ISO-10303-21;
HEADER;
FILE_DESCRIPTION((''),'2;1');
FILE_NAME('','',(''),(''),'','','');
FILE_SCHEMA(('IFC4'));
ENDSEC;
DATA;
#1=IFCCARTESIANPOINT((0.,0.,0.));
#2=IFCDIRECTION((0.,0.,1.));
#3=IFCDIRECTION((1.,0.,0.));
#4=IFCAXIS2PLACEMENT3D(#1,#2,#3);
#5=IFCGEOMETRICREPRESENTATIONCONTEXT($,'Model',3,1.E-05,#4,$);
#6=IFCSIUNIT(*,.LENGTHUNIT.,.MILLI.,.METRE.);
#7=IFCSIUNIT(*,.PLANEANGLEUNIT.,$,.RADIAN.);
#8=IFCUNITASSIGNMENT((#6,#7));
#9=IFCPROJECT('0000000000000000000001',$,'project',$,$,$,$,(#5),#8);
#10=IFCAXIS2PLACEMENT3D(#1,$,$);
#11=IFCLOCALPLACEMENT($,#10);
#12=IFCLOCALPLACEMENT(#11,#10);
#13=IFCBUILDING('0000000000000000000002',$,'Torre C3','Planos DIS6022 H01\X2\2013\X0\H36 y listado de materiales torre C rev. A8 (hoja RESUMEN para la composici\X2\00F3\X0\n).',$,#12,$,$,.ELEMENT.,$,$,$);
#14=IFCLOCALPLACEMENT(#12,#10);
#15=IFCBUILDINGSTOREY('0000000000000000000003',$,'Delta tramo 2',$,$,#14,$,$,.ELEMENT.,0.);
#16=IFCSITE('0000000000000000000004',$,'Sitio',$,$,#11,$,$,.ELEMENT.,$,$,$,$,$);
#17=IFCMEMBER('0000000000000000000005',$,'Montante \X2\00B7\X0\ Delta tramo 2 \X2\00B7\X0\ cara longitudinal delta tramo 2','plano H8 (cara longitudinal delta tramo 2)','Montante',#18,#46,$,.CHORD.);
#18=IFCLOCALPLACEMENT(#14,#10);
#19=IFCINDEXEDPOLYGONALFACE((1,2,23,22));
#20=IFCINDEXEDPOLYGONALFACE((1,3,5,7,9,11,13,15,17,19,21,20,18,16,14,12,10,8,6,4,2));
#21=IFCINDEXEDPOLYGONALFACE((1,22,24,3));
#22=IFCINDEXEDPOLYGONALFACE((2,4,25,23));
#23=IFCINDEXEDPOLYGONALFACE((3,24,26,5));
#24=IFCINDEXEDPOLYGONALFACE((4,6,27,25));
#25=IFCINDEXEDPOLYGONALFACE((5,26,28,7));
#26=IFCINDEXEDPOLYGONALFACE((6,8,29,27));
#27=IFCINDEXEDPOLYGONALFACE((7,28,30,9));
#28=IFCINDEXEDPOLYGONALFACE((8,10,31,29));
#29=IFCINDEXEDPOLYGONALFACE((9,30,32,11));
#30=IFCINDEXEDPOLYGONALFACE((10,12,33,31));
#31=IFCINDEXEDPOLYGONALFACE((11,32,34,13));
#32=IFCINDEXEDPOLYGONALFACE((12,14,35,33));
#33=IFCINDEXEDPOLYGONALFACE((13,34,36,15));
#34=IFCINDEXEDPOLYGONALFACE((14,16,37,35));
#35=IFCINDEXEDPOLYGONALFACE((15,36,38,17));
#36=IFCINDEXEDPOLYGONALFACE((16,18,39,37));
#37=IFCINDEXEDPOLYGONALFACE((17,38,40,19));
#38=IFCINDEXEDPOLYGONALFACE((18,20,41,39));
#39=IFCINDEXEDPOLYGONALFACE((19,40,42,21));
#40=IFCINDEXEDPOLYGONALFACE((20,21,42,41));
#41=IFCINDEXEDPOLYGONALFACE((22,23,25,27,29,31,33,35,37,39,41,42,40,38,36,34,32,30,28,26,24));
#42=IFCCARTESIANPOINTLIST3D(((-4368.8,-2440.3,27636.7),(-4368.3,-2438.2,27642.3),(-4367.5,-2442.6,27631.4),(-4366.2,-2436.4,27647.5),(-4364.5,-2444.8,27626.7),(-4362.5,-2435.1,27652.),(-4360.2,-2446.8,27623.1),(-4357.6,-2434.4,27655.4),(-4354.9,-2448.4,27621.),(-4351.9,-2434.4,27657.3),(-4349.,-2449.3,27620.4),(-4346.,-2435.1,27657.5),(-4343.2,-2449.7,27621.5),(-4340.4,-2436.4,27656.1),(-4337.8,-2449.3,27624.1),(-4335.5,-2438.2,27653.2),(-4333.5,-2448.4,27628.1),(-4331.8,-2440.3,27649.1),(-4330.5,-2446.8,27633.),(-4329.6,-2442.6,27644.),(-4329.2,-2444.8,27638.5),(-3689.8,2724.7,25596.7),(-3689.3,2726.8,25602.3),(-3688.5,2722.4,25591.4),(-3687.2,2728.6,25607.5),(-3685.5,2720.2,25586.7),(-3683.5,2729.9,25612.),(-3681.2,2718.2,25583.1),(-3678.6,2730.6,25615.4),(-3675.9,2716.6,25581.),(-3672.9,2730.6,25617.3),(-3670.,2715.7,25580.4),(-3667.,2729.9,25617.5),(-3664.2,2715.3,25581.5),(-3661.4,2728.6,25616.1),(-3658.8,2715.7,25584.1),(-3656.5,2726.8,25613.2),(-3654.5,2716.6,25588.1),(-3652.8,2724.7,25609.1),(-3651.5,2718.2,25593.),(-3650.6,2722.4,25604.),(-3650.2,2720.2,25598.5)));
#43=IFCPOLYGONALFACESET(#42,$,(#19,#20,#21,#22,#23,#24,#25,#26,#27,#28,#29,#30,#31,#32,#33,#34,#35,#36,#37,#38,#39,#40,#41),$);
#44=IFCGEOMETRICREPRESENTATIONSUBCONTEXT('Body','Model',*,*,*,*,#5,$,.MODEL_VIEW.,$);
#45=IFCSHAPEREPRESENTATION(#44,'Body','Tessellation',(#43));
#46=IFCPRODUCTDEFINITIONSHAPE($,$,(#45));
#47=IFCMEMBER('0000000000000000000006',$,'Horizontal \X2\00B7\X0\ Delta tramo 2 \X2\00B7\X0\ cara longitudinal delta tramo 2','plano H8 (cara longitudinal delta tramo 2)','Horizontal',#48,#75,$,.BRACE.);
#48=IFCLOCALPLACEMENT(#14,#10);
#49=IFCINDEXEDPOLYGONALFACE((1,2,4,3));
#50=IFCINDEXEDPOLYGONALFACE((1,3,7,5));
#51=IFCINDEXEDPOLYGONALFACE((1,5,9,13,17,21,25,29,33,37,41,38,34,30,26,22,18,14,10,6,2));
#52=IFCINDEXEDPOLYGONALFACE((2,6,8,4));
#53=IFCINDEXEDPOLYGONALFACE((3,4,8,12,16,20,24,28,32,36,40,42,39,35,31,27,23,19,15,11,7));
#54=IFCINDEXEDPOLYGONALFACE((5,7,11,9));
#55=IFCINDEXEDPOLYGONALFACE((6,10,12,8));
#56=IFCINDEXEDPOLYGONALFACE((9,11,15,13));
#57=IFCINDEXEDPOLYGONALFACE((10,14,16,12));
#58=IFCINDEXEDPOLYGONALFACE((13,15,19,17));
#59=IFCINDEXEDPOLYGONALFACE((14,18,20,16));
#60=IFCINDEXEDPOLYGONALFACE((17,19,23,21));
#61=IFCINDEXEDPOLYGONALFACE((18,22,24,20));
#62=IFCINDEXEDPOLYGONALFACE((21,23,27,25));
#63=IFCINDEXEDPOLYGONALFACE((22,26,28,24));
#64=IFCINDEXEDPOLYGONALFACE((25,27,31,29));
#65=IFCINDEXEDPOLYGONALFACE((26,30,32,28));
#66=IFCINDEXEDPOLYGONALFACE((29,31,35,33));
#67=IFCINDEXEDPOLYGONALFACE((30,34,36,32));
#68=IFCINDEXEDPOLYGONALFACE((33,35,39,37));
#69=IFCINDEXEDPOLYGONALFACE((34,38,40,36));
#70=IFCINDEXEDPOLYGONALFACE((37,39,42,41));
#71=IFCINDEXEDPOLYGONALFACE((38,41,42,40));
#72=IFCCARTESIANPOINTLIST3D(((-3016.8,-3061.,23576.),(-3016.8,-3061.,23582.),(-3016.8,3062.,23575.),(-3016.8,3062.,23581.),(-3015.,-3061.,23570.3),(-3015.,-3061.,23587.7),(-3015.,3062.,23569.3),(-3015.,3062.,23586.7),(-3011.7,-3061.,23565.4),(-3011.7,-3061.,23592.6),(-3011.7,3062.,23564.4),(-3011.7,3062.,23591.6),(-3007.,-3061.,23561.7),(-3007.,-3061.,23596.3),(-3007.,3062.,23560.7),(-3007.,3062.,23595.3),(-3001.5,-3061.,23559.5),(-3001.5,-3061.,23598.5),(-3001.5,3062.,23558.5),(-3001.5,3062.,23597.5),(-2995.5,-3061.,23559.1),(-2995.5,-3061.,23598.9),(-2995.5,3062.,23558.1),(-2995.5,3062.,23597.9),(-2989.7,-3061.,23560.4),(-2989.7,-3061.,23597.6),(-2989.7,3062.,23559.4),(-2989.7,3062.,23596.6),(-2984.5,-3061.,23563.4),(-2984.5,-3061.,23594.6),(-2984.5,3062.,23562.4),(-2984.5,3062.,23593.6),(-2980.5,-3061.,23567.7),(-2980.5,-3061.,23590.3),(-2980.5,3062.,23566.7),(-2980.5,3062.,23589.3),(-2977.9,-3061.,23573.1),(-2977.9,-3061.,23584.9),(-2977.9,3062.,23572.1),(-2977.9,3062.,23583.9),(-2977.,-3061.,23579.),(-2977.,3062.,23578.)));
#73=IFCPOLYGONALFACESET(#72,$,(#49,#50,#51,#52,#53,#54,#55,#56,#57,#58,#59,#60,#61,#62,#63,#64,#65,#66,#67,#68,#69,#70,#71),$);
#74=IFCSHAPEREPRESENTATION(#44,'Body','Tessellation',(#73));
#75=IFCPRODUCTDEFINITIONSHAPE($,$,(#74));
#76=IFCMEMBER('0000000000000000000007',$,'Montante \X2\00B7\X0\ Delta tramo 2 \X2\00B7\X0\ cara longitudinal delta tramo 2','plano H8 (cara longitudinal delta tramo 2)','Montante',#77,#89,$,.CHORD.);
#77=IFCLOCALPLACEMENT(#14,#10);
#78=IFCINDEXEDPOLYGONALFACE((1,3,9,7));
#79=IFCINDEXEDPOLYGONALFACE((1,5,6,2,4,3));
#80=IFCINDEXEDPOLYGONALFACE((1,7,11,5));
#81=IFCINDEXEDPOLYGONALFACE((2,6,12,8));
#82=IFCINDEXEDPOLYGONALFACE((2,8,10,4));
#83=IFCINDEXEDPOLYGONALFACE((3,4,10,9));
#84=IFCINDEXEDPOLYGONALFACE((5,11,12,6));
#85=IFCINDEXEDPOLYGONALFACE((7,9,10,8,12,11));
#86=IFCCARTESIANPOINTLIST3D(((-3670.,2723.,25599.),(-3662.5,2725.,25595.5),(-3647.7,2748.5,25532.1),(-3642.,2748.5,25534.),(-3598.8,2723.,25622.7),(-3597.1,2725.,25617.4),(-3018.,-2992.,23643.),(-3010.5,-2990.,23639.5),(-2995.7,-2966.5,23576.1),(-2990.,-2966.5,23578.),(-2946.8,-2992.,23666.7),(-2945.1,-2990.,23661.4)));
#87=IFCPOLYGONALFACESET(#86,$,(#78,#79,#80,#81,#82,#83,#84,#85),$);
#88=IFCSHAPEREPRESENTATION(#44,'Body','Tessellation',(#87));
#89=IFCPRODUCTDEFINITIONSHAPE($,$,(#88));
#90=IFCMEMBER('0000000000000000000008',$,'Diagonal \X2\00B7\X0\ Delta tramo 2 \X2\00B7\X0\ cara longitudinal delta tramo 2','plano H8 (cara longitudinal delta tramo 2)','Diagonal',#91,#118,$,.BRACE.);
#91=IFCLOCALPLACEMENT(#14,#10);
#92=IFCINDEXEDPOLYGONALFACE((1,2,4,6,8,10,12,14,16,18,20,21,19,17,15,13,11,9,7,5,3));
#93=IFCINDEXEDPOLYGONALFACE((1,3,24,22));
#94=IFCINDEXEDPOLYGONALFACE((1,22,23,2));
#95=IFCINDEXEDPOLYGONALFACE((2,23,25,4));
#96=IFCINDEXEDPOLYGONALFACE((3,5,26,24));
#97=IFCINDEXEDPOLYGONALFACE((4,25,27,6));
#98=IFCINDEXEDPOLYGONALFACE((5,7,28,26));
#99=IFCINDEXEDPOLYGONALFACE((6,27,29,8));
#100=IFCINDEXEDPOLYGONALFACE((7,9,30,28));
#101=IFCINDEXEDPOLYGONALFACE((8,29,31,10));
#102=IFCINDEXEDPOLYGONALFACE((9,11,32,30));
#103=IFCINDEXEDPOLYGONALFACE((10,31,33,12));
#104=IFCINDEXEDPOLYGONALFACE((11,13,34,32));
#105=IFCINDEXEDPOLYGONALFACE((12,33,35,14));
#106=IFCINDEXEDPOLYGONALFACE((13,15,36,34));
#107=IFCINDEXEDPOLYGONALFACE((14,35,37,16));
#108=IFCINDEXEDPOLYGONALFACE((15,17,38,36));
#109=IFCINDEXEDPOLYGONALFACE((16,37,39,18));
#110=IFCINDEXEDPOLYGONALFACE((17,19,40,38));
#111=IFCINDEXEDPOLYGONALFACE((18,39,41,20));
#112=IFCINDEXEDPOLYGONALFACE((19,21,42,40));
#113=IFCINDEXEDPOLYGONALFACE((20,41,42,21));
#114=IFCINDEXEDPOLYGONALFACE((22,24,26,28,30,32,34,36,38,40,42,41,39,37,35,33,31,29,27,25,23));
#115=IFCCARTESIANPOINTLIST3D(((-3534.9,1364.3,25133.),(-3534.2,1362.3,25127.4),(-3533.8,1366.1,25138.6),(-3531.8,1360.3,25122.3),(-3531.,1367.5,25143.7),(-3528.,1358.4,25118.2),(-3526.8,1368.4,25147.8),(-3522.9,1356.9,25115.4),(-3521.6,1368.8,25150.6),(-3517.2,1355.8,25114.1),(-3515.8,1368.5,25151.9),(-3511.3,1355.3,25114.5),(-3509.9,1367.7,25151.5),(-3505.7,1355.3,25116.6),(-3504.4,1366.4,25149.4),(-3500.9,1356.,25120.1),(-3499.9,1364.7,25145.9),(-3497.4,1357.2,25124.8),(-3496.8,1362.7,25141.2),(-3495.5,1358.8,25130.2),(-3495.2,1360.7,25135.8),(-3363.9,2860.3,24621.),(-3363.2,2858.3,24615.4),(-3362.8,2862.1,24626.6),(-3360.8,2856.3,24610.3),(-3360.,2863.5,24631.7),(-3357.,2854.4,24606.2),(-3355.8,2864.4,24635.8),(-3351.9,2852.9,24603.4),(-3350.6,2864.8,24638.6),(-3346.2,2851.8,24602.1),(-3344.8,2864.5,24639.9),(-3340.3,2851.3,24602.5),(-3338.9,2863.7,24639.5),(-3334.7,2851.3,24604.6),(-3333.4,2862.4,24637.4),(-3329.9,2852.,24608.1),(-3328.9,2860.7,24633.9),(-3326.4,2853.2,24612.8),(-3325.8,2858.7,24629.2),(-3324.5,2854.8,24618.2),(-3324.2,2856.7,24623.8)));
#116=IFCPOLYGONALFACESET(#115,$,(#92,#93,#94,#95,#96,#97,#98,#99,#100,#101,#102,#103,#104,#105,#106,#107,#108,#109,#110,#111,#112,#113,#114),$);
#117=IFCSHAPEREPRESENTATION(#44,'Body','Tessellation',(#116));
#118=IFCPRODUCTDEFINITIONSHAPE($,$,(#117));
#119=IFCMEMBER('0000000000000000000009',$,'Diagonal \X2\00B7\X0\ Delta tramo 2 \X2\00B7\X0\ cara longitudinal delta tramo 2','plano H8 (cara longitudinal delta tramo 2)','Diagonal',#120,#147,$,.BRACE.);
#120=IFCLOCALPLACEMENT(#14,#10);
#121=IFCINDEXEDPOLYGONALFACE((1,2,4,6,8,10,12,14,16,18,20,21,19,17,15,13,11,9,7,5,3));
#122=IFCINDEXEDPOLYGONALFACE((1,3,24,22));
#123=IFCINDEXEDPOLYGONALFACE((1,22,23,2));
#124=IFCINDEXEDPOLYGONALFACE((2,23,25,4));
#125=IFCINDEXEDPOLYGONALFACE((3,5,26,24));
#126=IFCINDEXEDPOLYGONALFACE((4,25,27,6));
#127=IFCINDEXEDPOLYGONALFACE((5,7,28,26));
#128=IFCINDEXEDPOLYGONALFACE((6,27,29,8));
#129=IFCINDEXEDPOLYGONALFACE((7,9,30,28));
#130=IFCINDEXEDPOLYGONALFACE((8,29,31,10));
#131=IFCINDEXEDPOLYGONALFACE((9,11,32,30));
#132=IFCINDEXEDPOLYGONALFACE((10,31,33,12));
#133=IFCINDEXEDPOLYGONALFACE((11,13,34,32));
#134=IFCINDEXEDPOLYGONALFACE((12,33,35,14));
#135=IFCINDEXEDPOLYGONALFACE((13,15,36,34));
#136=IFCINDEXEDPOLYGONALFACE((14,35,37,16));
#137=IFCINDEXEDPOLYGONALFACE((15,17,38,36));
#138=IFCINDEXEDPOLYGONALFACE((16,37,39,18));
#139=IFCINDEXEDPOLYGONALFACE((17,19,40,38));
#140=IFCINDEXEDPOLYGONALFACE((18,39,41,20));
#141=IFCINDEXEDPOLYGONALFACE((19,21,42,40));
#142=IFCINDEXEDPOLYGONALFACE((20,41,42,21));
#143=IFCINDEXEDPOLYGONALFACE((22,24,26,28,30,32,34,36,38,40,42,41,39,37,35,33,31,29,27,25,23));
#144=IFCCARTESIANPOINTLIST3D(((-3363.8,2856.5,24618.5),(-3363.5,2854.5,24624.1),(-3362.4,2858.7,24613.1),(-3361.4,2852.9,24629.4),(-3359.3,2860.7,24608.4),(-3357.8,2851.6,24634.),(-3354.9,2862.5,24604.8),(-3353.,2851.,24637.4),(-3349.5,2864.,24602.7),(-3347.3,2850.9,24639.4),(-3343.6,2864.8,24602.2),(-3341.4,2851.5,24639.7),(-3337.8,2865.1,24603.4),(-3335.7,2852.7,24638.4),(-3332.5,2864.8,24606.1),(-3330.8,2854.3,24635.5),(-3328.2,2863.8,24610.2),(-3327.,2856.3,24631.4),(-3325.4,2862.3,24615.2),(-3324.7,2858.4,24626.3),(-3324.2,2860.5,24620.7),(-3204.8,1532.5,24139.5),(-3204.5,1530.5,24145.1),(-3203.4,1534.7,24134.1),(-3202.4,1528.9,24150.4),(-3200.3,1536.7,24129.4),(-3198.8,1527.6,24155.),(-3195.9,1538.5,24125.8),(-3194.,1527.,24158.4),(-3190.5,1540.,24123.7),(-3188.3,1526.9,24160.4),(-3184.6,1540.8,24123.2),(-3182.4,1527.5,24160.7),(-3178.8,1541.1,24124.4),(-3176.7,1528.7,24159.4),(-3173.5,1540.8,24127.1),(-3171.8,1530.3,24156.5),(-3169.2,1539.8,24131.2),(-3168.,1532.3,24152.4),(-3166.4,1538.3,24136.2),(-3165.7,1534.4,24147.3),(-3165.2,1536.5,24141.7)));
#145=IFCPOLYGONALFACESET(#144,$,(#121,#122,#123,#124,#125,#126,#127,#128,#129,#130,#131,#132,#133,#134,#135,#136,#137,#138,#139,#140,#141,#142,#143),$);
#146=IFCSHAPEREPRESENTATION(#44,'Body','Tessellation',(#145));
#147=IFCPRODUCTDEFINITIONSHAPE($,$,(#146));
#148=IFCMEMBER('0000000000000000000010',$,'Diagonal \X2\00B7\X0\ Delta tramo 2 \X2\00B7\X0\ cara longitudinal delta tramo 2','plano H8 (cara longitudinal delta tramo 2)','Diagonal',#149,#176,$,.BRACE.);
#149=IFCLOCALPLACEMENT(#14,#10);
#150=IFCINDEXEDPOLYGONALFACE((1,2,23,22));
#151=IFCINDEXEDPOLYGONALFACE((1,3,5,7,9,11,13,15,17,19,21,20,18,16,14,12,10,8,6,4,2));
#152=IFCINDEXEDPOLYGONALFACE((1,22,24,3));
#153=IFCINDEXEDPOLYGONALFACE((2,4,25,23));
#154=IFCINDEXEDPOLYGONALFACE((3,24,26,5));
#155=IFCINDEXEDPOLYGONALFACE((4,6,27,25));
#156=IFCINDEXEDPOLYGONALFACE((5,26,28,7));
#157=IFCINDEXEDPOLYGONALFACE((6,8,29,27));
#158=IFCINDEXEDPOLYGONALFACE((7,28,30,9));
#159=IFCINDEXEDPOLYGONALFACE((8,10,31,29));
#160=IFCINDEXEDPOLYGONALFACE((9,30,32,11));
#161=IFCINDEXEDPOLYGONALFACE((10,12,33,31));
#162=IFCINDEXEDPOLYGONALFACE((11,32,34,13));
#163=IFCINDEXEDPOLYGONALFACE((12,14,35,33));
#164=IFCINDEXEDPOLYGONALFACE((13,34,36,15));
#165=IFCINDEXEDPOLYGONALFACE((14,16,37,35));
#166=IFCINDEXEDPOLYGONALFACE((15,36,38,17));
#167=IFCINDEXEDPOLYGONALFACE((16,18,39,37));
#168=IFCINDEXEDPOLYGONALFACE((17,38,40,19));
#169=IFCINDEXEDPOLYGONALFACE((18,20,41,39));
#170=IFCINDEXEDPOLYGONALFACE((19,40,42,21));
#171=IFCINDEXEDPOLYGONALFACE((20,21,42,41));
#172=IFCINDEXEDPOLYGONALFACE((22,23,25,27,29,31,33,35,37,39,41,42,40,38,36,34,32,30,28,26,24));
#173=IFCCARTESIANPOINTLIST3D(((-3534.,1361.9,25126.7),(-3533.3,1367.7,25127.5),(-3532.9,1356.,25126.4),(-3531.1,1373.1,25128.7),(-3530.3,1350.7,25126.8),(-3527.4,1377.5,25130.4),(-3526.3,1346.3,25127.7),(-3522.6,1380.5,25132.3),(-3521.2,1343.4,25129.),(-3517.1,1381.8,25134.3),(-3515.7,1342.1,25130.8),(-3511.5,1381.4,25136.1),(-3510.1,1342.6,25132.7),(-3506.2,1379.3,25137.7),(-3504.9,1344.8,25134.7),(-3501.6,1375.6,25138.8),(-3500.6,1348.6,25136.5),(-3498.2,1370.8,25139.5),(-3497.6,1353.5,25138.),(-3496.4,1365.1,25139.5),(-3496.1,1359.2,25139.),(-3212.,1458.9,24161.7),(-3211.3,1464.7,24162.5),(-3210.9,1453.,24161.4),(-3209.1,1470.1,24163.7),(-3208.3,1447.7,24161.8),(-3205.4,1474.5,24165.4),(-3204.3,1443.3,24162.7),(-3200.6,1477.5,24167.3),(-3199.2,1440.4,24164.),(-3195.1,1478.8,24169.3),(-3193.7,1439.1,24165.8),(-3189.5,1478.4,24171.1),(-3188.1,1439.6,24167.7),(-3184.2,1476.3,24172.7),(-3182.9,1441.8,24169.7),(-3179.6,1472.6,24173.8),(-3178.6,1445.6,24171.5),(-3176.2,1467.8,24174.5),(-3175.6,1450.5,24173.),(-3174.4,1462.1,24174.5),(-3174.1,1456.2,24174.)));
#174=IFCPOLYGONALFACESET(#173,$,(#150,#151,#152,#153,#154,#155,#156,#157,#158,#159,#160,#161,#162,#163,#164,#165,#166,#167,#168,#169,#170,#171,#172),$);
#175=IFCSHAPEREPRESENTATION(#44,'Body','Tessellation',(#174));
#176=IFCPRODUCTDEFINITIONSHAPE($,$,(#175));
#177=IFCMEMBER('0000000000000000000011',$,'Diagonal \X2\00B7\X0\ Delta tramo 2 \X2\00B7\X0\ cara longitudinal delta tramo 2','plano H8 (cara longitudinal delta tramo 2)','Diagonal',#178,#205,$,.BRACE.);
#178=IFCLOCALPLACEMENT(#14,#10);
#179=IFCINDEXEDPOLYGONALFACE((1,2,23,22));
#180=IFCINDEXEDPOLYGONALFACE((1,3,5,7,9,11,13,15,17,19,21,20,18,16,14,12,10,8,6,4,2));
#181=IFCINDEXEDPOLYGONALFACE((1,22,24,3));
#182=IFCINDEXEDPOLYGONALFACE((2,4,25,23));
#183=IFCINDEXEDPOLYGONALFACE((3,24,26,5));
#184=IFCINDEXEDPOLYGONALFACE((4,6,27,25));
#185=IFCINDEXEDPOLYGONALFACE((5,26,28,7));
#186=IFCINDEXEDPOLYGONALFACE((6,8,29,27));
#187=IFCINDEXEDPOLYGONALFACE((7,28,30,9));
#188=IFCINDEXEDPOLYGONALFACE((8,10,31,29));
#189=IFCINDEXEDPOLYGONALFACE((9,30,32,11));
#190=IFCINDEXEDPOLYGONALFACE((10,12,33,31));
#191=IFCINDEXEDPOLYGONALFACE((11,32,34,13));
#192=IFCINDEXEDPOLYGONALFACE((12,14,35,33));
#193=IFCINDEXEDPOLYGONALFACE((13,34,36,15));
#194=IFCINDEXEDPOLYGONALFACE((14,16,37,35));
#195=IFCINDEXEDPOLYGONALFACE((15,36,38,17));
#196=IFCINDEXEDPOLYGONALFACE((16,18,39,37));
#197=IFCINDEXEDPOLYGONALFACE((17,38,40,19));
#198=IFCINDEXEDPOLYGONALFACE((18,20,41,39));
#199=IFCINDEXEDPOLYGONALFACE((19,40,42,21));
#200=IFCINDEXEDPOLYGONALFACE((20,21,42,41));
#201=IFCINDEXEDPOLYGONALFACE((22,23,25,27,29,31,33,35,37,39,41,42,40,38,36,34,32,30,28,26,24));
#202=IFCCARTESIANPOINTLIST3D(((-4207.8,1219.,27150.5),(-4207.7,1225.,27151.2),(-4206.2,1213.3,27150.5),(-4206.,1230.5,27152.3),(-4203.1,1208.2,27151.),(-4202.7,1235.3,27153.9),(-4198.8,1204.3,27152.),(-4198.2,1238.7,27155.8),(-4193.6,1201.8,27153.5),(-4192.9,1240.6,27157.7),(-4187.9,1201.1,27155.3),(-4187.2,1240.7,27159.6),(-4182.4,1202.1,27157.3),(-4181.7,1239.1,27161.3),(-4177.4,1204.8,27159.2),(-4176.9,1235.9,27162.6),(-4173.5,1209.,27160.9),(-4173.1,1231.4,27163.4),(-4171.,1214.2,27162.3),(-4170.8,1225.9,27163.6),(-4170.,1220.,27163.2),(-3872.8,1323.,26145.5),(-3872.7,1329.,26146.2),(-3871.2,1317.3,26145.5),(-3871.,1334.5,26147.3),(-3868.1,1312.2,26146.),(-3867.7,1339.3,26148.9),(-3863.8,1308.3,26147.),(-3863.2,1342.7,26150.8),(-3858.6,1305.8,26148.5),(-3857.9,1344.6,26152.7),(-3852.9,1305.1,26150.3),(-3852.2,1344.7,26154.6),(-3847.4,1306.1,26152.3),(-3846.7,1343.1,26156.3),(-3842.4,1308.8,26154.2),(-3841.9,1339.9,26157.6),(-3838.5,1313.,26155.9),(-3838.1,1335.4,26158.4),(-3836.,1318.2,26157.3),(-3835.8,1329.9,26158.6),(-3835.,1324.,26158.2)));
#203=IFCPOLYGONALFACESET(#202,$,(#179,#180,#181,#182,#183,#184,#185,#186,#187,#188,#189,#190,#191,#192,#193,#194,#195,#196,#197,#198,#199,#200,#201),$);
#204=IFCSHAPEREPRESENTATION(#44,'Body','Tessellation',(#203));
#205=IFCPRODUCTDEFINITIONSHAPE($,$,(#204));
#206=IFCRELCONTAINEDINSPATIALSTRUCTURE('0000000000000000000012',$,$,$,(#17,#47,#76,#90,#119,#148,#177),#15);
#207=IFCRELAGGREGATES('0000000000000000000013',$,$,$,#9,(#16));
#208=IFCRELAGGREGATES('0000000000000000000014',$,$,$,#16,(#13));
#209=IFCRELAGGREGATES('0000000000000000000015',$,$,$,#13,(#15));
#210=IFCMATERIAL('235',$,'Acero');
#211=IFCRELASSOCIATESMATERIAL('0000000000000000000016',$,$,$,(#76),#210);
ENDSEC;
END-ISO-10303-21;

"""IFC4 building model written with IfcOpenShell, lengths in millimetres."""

from ifc_helpers import new_model, si_unit, frame, frame_2d, origin, origin_with_axes, place, context, subcontext, project, spatial, circle, l_section, extrude, material, element, save


model = new_model("IFC4")

# Units and contexts
model_context = context("Model", 3, precision=1e-05, world=origin_with_axes())
body_context = subcontext(model_context, "Body", "Model", "MODEL_VIEW")
ifc_project = project(units=[si_unit("LENGTHUNIT", "METRE", prefix="MILLI"), si_unit("PLANEANGLEUNIT", "RADIAN")], contexts=[model_context])

# Site, building, storey
site_placement = place(None, origin())
site = spatial("IfcSite", under=ifc_project, at=site_placement, Name="Sitio", CompositionType="ELEMENT")
building_placement = place(site_placement, origin())
building = spatial("IfcBuilding", under=site, at=building_placement, Name="Torre C3", Description="Planos DIS6022 H01–H36 y listado de materiales torre C rev. A8 (hoja RESUMEN para la composición).", CompositionType="ELEMENT")
storey_placement = place(building_placement, origin())
storey = spatial("IfcBuildingStorey", under=building, at=storey_placement, Name="Delta tramo 2", CompositionType="ELEMENT", Elevation=0.0)

# Members
member_1_placement = place(storey_placement, frame((-3670.0, 2723.0, 25599.0), z_axis=(-0.121366, -0.923207, 0.364635), x_axis=(0.291557, -0.384303, -0.87596)))
element("IfcMember", 1, at=member_1_placement, inside=storey, Name="Montante · Delta tramo 2 · cara longitudinal delta tramo 2", Description="plano H8 (cara longitudinal delta tramo 2)", ObjectType="Montante", PredefinedType="CHORD", context=body_context, shape_type="SweptSolid", body=[
    extrude(circle(Radius=20.0), None, (0.0, 0.0, 1.0), 5594.6),
])
member_2_placement = place(storey_placement, frame((-2997.0, 3062.0, 23578.0), z_axis=(0.0, -1.0, 0.000163), x_axis=(1.0, 0.0, 0.0)))
element("IfcMember", 2, at=member_2_placement, inside=storey, Name="Horizontal · Delta tramo 2 · cara longitudinal delta tramo 2", Description="plano H8 (cara longitudinal delta tramo 2)", ObjectType="Horizontal", PredefinedType="BRACE", context=body_context, shape_type="SweptSolid", body=[
    extrude(circle(Radius=20.0), None, (0.0, 0.0, 1.0), 6123.0),
])
ifc_material = material(Name="235", Category="Acero")
member_3_placement = place(storey_placement, frame((-3670.0, 2723.0, 25599.0), z_axis=(0.107315, -0.940656, -0.321946), x_axis=(0.297462, 0.339361, -0.892385)))
element("IfcMember", 3, at=member_3_placement, inside=storey, material=ifc_material, Name="Montante · Delta tramo 2 · cara longitudinal delta tramo 2", Description="plano H8 (cara longitudinal delta tramo 2)", ObjectType="Montante", PredefinedType="CHORD", context=body_context, shape_type="SweptSolid", body=[
    extrude(l_section(Depth=75.0, Width=75.0, Thickness=6.0, at=frame_2d((37.5, 37.5))), None, (0.0, 0.0, 1.0), 6075.5),
])
member_4_placement = place(storey_placement, frame((-3515.0, 1362.0, 25133.0), z_axis=(0.10752, 0.940639, -0.32193), x_axis=(0.976994, -0.159952, -0.141059)))
element("IfcMember", 4, at=member_4_placement, inside=storey, Name="Diagonal · Delta tramo 2 · cara longitudinal delta tramo 2", Description="plano H8 (cara longitudinal delta tramo 2)", ObjectType="Diagonal", PredefinedType="BRACE", context=body_context, shape_type="SweptSolid", body=[
    extrude(circle(Radius=20.0), None, (0.0, 0.0, 1.0), 1590.4),
])
member_5_placement = place(storey_placement, frame((-3344.0, 2858.0, 24621.0), z_axis=(0.112214, -0.934413, -0.338054), x_axis=(0.964462, 0.020521, 0.263423)))
element("IfcMember", 5, at=member_5_placement, inside=storey, Name="Diagonal · Delta tramo 2 · cara longitudinal delta tramo 2", Description="plano H8 (cara longitudinal delta tramo 2)", ObjectType="Diagonal", PredefinedType="BRACE", context=body_context, shape_type="SweptSolid", body=[
    extrude(circle(Radius=20.0), None, (0.0, 0.0, 1.0), 1416.9),
])
member_6_placement = place(storey_placement, frame((-3515.0, 1362.0, 25133.0), z_axis=(0.315094, 0.094919, -0.944302), x_axis=(0.870343, -0.425656, 0.247629)))
element("IfcMember", 6, at=member_6_placement, inside=storey, Name="Diagonal · Delta tramo 2 · cara longitudinal delta tramo 2", Description="plano H8 (cara longitudinal delta tramo 2)", ObjectType="Diagonal", PredefinedType="BRACE", context=body_context, shape_type="SweptSolid", body=[
    extrude(circle(Radius=20.0), None, (0.0, 0.0, 1.0), 1021.9),
])
member_7_placement = place(storey_placement, frame((-3854.0, 1325.0, 26152.0), z_axis=(-0.314715, -0.097703, 0.944144), x_axis=(0.901862, -0.340939, 0.26534)))
element("IfcMember", 7, at=member_7_placement, inside=storey, Name="Diagonal · Delta tramo 2 · cara longitudinal delta tramo 2", Description="plano H8 (cara longitudinal delta tramo 2)", ObjectType="Diagonal", PredefinedType="BRACE", context=body_context, shape_type="SweptSolid", body=[
    extrude(circle(Radius=20.0), None, (0.0, 0.0, 1.0), 1064.5),
])

save(model, "model.ifc")
